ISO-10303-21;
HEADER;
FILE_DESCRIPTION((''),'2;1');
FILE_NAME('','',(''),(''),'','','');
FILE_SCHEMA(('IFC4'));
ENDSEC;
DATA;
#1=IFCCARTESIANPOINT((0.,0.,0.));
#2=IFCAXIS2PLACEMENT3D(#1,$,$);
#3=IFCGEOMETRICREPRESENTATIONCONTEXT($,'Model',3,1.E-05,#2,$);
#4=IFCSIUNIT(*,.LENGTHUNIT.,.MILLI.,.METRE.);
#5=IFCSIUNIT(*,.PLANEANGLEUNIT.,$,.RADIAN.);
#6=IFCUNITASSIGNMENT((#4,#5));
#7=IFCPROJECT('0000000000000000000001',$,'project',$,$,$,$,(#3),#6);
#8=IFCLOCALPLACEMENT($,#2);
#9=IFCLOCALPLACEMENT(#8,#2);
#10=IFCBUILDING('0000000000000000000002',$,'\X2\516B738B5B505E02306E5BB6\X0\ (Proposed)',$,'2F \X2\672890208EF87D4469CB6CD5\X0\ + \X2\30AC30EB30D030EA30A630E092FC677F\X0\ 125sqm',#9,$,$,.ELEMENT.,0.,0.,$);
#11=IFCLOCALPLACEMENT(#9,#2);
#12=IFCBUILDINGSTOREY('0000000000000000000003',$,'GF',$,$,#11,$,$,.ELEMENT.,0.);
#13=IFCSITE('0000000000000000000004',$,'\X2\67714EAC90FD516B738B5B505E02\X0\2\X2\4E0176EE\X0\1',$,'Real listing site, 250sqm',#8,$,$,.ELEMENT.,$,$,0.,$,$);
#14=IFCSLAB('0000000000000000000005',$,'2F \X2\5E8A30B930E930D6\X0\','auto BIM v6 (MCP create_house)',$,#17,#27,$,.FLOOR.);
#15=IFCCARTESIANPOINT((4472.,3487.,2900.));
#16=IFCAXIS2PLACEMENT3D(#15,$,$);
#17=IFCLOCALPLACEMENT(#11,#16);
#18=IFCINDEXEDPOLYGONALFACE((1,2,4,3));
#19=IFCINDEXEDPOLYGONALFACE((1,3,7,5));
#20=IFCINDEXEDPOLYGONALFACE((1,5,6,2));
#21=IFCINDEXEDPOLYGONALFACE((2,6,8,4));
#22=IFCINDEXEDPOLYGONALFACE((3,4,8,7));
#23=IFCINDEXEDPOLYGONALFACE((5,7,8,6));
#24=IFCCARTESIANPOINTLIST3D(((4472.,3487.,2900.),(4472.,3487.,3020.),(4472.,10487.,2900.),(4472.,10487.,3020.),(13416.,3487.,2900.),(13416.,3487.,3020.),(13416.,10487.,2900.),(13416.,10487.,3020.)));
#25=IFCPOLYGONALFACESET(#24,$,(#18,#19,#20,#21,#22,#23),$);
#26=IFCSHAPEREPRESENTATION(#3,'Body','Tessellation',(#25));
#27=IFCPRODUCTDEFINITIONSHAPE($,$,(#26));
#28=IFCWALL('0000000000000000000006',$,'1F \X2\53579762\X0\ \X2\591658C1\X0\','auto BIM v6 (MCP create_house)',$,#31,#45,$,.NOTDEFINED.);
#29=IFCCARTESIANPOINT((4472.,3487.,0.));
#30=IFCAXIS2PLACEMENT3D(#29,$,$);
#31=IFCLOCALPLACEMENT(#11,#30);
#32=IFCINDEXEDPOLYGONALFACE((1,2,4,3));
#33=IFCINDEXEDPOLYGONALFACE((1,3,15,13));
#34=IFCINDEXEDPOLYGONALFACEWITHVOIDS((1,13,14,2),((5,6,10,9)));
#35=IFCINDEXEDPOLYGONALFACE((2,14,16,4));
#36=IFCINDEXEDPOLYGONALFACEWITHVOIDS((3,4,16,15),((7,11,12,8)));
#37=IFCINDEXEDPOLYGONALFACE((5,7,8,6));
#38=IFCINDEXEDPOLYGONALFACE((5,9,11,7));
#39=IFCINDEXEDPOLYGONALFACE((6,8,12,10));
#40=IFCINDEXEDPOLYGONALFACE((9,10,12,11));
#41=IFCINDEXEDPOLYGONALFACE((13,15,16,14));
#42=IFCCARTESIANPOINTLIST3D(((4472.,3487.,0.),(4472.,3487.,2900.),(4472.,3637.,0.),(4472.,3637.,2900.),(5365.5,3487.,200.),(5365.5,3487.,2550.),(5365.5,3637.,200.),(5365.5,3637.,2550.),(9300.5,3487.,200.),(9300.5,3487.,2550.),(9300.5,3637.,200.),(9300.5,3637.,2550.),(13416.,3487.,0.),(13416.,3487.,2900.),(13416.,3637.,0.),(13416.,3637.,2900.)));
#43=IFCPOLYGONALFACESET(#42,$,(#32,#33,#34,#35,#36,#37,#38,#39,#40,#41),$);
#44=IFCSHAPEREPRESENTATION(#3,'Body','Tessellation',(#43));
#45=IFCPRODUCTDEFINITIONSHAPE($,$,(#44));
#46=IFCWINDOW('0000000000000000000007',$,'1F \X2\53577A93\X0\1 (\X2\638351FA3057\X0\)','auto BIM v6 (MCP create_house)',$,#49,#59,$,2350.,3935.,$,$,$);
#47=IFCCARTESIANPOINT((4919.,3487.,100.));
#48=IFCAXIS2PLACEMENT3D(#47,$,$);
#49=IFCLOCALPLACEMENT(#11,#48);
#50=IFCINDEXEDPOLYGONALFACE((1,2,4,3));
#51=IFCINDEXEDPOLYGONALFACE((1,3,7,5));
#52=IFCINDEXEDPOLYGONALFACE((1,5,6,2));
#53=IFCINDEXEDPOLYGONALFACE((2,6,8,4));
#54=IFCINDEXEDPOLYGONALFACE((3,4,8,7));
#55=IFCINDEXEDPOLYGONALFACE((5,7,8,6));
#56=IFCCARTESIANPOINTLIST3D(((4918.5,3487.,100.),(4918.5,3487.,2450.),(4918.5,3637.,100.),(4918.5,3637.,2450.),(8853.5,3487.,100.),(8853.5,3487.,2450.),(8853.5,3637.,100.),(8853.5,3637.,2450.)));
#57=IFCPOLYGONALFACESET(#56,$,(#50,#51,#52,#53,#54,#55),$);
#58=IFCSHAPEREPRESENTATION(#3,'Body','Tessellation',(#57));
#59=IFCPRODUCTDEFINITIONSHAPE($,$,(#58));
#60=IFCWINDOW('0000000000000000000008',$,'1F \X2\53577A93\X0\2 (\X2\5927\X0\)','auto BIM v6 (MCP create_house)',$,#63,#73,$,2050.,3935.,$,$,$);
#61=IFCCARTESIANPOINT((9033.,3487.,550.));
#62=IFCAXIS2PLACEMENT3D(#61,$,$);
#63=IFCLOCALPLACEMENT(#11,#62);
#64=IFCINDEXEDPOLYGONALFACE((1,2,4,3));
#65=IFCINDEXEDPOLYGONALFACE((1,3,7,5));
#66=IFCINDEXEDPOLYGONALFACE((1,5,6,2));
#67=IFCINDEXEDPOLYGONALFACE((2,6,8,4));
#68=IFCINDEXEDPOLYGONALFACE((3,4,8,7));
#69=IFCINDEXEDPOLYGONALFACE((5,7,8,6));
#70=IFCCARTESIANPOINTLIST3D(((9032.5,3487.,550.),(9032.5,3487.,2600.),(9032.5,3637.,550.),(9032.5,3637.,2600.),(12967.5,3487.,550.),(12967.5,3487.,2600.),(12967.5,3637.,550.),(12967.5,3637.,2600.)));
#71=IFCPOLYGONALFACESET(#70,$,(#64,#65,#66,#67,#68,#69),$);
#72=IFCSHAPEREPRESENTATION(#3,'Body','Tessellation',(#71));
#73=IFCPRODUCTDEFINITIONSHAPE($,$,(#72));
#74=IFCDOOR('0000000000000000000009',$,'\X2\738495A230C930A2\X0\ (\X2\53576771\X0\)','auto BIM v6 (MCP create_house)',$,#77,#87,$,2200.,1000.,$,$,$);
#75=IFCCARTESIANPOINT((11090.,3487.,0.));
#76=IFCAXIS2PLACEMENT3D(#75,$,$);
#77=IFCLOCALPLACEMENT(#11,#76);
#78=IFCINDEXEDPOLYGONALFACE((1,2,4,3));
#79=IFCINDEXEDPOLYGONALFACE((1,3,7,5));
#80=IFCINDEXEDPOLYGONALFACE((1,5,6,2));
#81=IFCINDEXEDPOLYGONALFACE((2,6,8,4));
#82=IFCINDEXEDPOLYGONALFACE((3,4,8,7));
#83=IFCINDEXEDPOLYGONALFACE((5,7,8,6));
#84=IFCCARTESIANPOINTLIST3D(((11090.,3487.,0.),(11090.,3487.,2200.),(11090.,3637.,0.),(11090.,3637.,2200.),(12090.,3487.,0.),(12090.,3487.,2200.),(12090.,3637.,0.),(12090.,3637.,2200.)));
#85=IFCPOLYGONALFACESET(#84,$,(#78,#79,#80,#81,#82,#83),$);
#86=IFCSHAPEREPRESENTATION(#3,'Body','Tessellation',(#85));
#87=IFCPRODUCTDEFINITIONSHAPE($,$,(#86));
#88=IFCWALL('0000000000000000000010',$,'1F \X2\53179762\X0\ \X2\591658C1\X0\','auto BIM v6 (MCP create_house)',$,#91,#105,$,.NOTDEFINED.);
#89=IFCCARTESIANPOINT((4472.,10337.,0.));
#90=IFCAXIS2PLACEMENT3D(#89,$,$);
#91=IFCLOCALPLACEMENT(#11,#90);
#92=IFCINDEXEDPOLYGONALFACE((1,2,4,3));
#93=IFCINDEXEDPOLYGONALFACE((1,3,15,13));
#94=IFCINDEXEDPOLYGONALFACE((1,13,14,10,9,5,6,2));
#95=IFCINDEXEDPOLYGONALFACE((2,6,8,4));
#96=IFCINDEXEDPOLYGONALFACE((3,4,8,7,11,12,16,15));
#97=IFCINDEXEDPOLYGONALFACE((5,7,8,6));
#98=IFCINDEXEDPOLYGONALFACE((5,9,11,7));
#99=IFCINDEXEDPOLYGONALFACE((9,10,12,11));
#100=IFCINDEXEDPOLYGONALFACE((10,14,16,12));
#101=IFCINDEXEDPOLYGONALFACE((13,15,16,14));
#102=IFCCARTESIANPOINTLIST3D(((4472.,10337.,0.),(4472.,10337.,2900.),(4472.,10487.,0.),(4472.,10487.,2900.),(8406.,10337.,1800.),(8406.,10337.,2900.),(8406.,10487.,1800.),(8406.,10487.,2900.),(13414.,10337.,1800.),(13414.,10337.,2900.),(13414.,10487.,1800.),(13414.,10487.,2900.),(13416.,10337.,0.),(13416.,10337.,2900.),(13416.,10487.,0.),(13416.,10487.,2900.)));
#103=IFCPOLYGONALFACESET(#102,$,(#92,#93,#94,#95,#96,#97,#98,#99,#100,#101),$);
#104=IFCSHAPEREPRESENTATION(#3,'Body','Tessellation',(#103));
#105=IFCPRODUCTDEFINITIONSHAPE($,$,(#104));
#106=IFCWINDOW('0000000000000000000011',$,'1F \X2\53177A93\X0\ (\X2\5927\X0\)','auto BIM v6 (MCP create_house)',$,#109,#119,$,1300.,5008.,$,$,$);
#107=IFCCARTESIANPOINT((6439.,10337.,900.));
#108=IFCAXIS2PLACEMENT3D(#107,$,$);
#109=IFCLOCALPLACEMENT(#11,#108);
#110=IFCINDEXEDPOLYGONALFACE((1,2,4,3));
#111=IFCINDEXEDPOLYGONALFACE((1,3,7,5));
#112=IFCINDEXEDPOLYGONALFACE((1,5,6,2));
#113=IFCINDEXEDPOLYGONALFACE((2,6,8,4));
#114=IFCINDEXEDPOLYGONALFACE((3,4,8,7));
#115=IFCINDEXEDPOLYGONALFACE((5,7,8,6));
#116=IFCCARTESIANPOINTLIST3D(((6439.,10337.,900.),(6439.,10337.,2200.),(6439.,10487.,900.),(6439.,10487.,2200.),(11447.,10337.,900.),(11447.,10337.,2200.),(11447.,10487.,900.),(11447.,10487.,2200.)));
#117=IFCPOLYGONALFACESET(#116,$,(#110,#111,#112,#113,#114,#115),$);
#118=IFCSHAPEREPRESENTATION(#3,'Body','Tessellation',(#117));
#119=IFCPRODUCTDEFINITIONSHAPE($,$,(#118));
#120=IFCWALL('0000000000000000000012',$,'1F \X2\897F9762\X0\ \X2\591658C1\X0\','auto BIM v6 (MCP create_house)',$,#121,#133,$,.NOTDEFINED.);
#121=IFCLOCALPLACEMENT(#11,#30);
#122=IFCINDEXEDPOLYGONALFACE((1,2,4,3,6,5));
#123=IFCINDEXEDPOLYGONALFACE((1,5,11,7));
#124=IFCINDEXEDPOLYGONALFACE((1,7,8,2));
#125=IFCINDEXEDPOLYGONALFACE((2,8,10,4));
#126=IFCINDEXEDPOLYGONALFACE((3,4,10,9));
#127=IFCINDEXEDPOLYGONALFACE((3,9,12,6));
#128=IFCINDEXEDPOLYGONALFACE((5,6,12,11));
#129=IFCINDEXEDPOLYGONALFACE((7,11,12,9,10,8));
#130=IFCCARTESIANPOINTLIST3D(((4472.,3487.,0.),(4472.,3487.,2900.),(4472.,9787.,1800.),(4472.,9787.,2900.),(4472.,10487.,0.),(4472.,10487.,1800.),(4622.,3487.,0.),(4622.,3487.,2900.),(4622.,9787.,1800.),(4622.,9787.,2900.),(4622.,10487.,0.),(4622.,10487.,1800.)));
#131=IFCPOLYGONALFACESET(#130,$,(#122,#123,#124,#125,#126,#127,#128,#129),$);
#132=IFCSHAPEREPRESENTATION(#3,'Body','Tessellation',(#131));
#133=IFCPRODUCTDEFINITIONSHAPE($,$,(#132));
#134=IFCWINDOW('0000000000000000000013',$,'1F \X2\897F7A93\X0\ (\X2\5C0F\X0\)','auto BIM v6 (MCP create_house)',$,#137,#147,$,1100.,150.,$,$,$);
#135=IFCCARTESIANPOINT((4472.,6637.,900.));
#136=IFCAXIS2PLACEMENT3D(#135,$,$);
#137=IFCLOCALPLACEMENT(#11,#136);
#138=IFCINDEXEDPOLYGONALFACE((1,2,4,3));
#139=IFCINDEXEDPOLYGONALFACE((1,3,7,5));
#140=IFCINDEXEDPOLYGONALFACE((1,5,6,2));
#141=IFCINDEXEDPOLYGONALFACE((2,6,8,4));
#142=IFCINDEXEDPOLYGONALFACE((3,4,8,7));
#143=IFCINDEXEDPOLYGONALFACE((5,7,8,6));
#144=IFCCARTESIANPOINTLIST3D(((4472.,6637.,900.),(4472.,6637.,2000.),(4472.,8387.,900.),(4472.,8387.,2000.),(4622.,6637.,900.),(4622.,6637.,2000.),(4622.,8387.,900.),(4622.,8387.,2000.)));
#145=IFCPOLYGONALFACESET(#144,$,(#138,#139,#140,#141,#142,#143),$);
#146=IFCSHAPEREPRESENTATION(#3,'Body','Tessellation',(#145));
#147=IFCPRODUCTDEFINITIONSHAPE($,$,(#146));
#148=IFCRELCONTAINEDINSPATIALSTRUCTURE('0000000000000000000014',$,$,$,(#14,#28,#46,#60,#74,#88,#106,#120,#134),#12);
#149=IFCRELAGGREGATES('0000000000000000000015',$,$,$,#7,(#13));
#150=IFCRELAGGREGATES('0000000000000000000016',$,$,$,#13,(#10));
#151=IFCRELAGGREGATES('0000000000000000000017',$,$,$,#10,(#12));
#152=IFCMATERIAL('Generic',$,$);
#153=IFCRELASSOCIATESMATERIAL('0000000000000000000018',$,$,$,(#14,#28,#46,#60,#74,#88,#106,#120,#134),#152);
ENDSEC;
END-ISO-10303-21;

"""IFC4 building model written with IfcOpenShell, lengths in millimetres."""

from ifc_helpers import new_model, si_unit, frame, frame_2d, origin, place, context, project, spatial, rectangle, extrude, material, element, fill, save


model = new_model("IFC4")

# Units and contexts
model_context = context("Model", 3, precision=1e-05, world=origin())
ifc_project = project(units=[si_unit("LENGTHUNIT", "METRE", prefix="MILLI"), si_unit("PLANEANGLEUNIT", "RADIAN")], contexts=[model_context])

# Site, building, storey
site_placement = place(None, origin())
site = spatial("IfcSite", under=ifc_project, at=site_placement, Name="東京都八王子市2丁目1", ObjectType="Real listing site, 250sqm", CompositionType="ELEMENT", RefElevation=0.0)
building_placement = place(site_placement, origin())
building = spatial("IfcBuilding", under=site, at=building_placement, Name="八王子市の家 (Proposed)", ObjectType="2F 木造軸組構法 + ガルバリウム鋼板 125sqm", CompositionType="ELEMENT", ElevationOfRefHeight=0.0, ElevationOfTerrain=0.0)
storey_placement = place(building_placement, origin())
storey = spatial("IfcBuildingStorey", under=building, at=storey_placement, Name="GF", CompositionType="ELEMENT", Elevation=0.0)

# Slab
ifc_material = material(Name="Generic")
slab_1_placement = place(storey_placement, frame((4472.0, 3487.0, 2900.0)))
element("IfcSlab", 1, at=slab_1_placement, inside=storey, material=ifc_material, Name="2F 床スラブ", Description="auto BIM v6 (MCP create_house)", PredefinedType="FLOOR", context=model_context, shape_type="SweptSolid", body=[
    extrude(rectangle(XDim=8944.0, YDim=7000.0, at=frame_2d((4472.0, 3500.0))), frame((4472.0, 3487.0, 2900.0)), (0.0, 0.0, 1.0), 120.0),
])

# Wall, openings, windows, door
wall_1_placement = place(storey_placement, frame((4472.0, 3487.0, 0.0)))
wall_1 = element("IfcWall", 2, at=wall_1_placement, inside=storey, material=ifc_material, Name="1F 南面 外壁", Description="auto BIM v6 (MCP create_house)", PredefinedType="NOTDEFINED", context=model_context, shape_type="SweptSolid", body=[
    extrude(rectangle(XDim=8944.0, YDim=150.0, at=frame_2d((4472.0, 75.0))), frame((4472.0, 3487.0, 0.0)), (0.0, 0.0, 1.0), 2900.0),
])
opening_1_placement = place(storey_placement, frame((4919.0, 3487.0, 100.0)))
opening_1 = element("IfcOpeningElement", 3, at=opening_1_placement, cuts=wall_1, PredefinedType="NOTDEFINED", context=model_context, shape_type="SweptSolid", body=[
    extrude(rectangle(XDim=3935.0, YDim=150.0, at=frame_2d((1967.0, 75.0))), frame((4919.0, 3487.0, 100.0)), (0.0, 0.0, 1.0), 2350.0),
])
opening_2_placement = place(storey_placement, frame((9033.0, 3487.0, 550.0)))
opening_2 = element("IfcOpeningElement", 4, at=opening_2_placement, cuts=wall_1, PredefinedType="NOTDEFINED", context=model_context, shape_type="SweptSolid", body=[
    extrude(rectangle(XDim=3935.0, YDim=150.0, at=frame_2d((1967.0, 75.0))), frame((9033.0, 3487.0, 550.0)), (0.0, 0.0, 1.0), 2050.0),
])
opening_3_placement = place(storey_placement, frame((11090.0, 3487.0, 0.0)))
opening_3 = element("IfcOpeningElement", 5, at=opening_3_placement, cuts=wall_1, PredefinedType="NOTDEFINED", context=model_context, shape_type="SweptSolid", body=[
    extrude(rectangle(XDim=1000.0, YDim=150.0, at=frame_2d((500.0, 75.0))), frame((11090.0, 3487.0, 0.0)), (0.0, 0.0, 1.0), 2200.0),
])
window_1_placement = place(storey_placement, frame((4919.0, 3487.0, 100.0)))
window_1 = element("IfcWindow", 6, at=window_1_placement, inside=storey, material=ifc_material, Name="1F 南窓1 (掃出し)", Description="auto BIM v6 (MCP create_house)", OverallHeight=2350.0, OverallWidth=3935.0, context=model_context, shape_type="SweptSolid", body=[
    extrude(rectangle(XDim=3935.0, YDim=150.0, at=frame_2d((1967.0, 75.0))), frame((4919.0, 3487.0, 100.0)), (0.0, 0.0, 1.0), 2350.0),
])
fill(opening_1, window_1)
window_2_placement = place(storey_placement, frame((9033.0, 3487.0, 550.0)))
window_2 = element("IfcWindow", 7, at=window_2_placement, inside=storey, material=ifc_material, Name="1F 南窓2 (大)", Description="auto BIM v6 (MCP create_house)", OverallHeight=2050.0, OverallWidth=3935.0, context=model_context, shape_type="SweptSolid", body=[
    extrude(rectangle(XDim=3935.0, YDim=150.0, at=frame_2d((1967.0, 75.0))), frame((9033.0, 3487.0, 550.0)), (0.0, 0.0, 1.0), 2050.0),
])
fill(opening_2, window_2)
door_placement = place(storey_placement, frame((11090.0, 3487.0, 0.0)))
door = element("IfcDoor", 8, at=door_placement, inside=storey, material=ifc_material, Name="玄関ドア (南東)", Description="auto BIM v6 (MCP create_house)", OverallHeight=2200.0, OverallWidth=1000.0, context=model_context, shape_type="SweptSolid", body=[
    extrude(rectangle(XDim=1000.0, YDim=150.0, at=frame_2d((500.0, 75.0))), frame((11090.0, 3487.0, 0.0)), (0.0, 0.0, 1.0), 2200.0),
])
fill(opening_3, door)

# Walls, openings, windows
wall_2_placement = place(storey_placement, frame((4472.0, 10337.0, 0.0)))
wall_2 = element("IfcWall", 9, at=wall_2_placement, inside=storey, material=ifc_material, Name="1F 北面 外壁", Description="auto BIM v6 (MCP create_house)", PredefinedType="NOTDEFINED", context=model_context, shape_type="SweptSolid", body=[
    extrude(rectangle(XDim=8944.0, YDim=150.0, at=frame_2d((4472.0, 75.0))), frame((4472.0, 10337.0, 0.0)), (0.0, 0.0, 1.0), 2900.0),
])
opening_4_placement = place(storey_placement, frame((6439.0, 10337.0, 900.0)))
opening_4 = element("IfcOpeningElement", 10, at=opening_4_placement, cuts=wall_2, PredefinedType="NOTDEFINED", context=model_context, shape_type="SweptSolid", body=[
    extrude(rectangle(XDim=5008.0, YDim=150.0, at=frame_2d((2504.0, 75.0))), frame((6439.0, 10337.0, 900.0)), (0.0, 0.0, 1.0), 1300.0),
])
window_3_placement = place(storey_placement, frame((6439.0, 10337.0, 900.0)))
window_3 = element("IfcWindow", 11, at=window_3_placement, inside=storey, material=ifc_material, Name="1F 北窓 (大)", Description="auto BIM v6 (MCP create_house)", OverallHeight=1300.0, OverallWidth=5008.0, context=model_context, shape_type="SweptSolid", body=[
    extrude(rectangle(XDim=5008.0, YDim=150.0, at=frame_2d((2504.0, 75.0))), frame((6439.0, 10337.0, 900.0)), (0.0, 0.0, 1.0), 1300.0),
])
fill(opening_4, window_3)
wall_3_placement = place(storey_placement, frame((4472.0, 3487.0, 0.0)))
wall_3 = element("IfcWall", 12, at=wall_3_placement, inside=storey, material=ifc_material, Name="1F 西面 外壁", Description="auto BIM v6 (MCP create_house)", PredefinedType="NOTDEFINED", context=model_context, shape_type="SweptSolid", body=[
    extrude(rectangle(XDim=150.0, YDim=7000.0, at=frame_2d((75.0, 3500.0))), frame((4472.0, 3487.0, 0.0)), (0.0, 0.0, 1.0), 2900.0),
])
opening_5_placement = place(storey_placement, frame((4472.0, 6637.0, 900.0)))
opening_5 = element("IfcOpeningElement", 13, at=opening_5_placement, cuts=wall_3, PredefinedType="NOTDEFINED", context=model_context, shape_type="SweptSolid", body=[
    extrude(rectangle(XDim=150.0, YDim=1750.0, at=frame_2d((75.0, 875.0))), frame((4472.0, 6637.0, 900.0)), (0.0, 0.0, 1.0), 1100.0),
])
window_4_placement = place(storey_placement, frame((4472.0, 6637.0, 900.0)))
window_4 = element("IfcWindow", 14, at=window_4_placement, inside=storey, material=ifc_material, Name="1F 西窓 (小)", Description="auto BIM v6 (MCP create_house)", OverallHeight=1100.0, OverallWidth=150.0, context=model_context, shape_type="SweptSolid", body=[
    extrude(rectangle(XDim=150.0, YDim=1750.0, at=frame_2d((75.0, 875.0))), frame((4472.0, 6637.0, 900.0)), (0.0, 0.0, 1.0), 1100.0),
])
fill(opening_5, window_4)

save(model, "model.ifc")
